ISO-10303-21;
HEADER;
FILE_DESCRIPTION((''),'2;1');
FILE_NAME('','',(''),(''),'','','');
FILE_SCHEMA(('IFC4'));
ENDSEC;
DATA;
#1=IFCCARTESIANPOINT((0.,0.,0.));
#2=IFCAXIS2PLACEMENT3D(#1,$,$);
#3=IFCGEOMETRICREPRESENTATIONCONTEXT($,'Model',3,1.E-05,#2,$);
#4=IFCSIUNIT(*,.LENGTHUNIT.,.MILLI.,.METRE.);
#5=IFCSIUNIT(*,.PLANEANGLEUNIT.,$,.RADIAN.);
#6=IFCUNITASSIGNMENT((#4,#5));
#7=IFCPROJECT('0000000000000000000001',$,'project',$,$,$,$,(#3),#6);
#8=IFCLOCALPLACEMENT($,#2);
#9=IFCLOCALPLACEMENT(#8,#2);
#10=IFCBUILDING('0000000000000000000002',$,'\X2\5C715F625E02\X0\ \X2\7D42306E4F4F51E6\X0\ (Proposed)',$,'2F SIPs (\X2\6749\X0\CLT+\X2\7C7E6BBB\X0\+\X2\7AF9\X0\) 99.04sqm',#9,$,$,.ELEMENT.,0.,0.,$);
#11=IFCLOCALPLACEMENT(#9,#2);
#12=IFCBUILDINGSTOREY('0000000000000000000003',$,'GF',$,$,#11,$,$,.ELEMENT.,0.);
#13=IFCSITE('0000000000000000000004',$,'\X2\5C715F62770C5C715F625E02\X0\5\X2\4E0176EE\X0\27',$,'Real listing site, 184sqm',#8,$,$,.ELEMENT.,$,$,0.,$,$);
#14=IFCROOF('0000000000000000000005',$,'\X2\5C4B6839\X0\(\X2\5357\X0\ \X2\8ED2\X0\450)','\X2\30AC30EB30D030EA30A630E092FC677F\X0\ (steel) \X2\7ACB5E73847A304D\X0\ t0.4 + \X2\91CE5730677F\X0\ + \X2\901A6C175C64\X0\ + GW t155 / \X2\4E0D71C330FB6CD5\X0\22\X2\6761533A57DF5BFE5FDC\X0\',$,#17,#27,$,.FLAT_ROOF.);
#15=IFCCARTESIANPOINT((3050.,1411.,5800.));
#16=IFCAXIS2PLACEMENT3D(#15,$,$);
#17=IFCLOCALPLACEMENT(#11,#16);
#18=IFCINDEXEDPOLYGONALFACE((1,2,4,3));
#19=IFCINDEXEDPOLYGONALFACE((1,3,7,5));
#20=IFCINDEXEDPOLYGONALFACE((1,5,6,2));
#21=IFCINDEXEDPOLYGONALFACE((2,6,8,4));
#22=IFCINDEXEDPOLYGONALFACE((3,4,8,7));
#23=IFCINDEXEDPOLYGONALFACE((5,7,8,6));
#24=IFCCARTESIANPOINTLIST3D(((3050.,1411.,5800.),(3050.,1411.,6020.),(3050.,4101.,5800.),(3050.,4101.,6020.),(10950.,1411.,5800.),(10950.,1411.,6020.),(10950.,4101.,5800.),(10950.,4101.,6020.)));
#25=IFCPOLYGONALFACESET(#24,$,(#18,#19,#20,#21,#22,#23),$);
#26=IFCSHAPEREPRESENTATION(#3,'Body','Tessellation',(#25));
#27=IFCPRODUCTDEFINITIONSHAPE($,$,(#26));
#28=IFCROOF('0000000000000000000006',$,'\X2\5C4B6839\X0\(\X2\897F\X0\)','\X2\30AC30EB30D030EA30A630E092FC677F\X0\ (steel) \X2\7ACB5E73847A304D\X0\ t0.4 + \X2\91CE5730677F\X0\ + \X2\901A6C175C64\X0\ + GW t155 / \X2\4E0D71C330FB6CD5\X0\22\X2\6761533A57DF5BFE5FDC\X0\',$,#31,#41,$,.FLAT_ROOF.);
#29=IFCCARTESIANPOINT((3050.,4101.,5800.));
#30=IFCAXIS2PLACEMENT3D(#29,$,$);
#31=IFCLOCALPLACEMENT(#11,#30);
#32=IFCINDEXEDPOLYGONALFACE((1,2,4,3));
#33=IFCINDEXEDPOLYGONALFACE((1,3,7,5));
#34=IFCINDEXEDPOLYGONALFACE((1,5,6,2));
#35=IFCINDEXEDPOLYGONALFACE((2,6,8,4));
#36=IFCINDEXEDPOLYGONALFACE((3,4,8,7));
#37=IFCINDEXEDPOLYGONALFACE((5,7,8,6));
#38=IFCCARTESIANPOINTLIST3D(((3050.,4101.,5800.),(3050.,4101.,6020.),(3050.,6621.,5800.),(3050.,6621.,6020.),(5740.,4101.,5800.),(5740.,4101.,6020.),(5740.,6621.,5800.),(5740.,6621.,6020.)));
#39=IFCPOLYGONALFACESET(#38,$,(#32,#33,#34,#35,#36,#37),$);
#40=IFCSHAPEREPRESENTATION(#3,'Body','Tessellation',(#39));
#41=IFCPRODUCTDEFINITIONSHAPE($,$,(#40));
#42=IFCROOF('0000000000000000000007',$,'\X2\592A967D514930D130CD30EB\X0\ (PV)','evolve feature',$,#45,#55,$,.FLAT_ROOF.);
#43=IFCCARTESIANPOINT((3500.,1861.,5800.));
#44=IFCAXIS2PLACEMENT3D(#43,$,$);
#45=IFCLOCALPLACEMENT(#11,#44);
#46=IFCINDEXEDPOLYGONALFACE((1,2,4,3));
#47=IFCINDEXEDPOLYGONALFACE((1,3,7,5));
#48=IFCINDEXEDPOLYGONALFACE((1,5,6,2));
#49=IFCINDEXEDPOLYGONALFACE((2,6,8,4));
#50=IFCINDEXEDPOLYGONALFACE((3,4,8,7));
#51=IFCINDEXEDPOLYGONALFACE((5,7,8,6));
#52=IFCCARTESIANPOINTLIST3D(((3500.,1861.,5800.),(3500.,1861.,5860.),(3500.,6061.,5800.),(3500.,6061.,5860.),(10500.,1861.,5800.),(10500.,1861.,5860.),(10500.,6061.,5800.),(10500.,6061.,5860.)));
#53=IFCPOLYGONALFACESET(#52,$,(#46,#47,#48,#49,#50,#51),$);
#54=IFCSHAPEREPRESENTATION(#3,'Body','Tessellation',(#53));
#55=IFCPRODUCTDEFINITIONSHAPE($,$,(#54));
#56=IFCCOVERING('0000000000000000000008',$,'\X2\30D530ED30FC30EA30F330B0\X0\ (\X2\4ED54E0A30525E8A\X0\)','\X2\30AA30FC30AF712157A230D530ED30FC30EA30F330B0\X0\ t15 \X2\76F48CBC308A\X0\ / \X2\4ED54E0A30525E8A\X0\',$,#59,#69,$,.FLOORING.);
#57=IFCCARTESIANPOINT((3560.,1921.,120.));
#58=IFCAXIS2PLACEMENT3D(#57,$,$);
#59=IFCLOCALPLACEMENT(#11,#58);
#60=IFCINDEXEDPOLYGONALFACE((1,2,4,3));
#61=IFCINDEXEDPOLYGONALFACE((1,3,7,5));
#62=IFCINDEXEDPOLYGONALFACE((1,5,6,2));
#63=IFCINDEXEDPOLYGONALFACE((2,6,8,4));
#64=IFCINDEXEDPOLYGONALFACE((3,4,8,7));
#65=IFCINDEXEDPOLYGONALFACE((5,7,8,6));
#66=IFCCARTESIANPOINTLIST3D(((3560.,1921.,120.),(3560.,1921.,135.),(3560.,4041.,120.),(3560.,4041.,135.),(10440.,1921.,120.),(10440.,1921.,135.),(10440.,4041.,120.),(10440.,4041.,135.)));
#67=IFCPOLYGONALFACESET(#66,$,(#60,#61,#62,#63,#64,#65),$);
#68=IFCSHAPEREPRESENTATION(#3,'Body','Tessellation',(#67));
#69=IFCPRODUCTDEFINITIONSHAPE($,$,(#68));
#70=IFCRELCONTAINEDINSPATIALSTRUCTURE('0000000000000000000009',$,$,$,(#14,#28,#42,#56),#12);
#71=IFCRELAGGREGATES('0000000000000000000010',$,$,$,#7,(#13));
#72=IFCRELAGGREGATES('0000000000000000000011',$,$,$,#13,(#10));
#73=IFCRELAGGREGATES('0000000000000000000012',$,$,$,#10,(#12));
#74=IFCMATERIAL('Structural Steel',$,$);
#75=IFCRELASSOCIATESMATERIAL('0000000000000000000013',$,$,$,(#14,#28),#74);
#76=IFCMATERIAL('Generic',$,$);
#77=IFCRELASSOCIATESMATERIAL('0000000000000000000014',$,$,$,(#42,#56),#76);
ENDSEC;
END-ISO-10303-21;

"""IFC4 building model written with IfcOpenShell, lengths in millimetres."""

from ifc_helpers import new_model, si_unit, frame, frame_2d, origin, place, context, project, spatial, rectangle, extrude, material, element, save


model = new_model("IFC4")

# Units and contexts
model_context = context("Model", 3, precision=1e-05, world=origin())
ifc_project = project(units=[si_unit("LENGTHUNIT", "METRE", prefix="MILLI"), si_unit("PLANEANGLEUNIT", "RADIAN")], contexts=[model_context])

# Site, building, storey
site_placement = place(None, origin())
site = spatial("IfcSite", under=ifc_project, at=site_placement, Name="山形県山形市5丁目27", ObjectType="Real listing site, 184sqm", CompositionType="ELEMENT", RefElevation=0.0)
building_placement = place(site_placement, origin())
building = spatial("IfcBuilding", under=site, at=building_placement, Name="山形市 終の住処 (Proposed)", ObjectType="2F SIPs (杉CLT+籾殻+竹) 99.04sqm", CompositionType="ELEMENT", ElevationOfRefHeight=0.0, ElevationOfTerrain=0.0)
storey_placement = place(building_placement, origin())
storey = spatial("IfcBuildingStorey", under=building, at=storey_placement, Name="GF", CompositionType="ELEMENT", Elevation=0.0)

# Shared definitions
ifc_material_1 = material(Name="Generic")

# Roofs
ifc_material_2 = material(Name="Structural Steel")
roof_1_placement = place(storey_placement, frame((3050.0, 1411.0, 5800.0)))
element("IfcRoof", 1, at=roof_1_placement, inside=storey, material=ifc_material_2, Name="屋根(南 軒450)", Description="ガルバリウム鋼板 (steel) 立平葺き t0.4 + 野地板 + 通気層 + GW t155 / 不燃・法22条区域対応", PredefinedType="FLAT_ROOF", context=model_context, shape_type="SweptSolid", body=[
    extrude(rectangle(XDim=7900.0, YDim=2690.0, at=frame_2d((3950.0, 1345.0))), frame((3050.0, 1411.0, 5800.0)), (0.0, 0.0, 1.0), 220.0),
])
roof_2_placement = place(storey_placement, frame((3050.0, 4101.0, 5800.0)))
element("IfcRoof", 2, at=roof_2_placement, inside=storey, material=ifc_material_2, Name="屋根(西)", Description="ガルバリウム鋼板 (steel) 立平葺き t0.4 + 野地板 + 通気層 + GW t155 / 不燃・法22条区域対応", PredefinedType="FLAT_ROOF", context=model_context, shape_type="SweptSolid", body=[
    extrude(rectangle(XDim=2690.0, YDim=2520.0, at=frame_2d((1345.0, 1260.0))), frame((3050.0, 4101.0, 5800.0)), (0.0, 0.0, 1.0), 220.0),
])
roof_3_placement = place(storey_placement, frame((3500.0, 1861.0, 5800.0)))
element("IfcRoof", 3, at=roof_3_placement, inside=storey, material=ifc_material_1, Name="太陽光パネル (PV)", Description="evolve feature", PredefinedType="FLAT_ROOF", context=model_context, shape_type="SweptSolid", body=[
    extrude(rectangle(XDim=7000.0, YDim=4200.0, at=frame_2d((3500.0, 2100.0))), frame((3500.0, 1861.0, 5800.0)), (0.0, 0.0, 1.0), 60.0),
])

# Covering
covering_placement = place(storey_placement, frame((3560.0, 1921.0, 120.0)))
element("IfcCovering", 4, at=covering_placement, inside=storey, material=ifc_material_1, Name="フローリング (仕上げ床)", Description="オーク無垢フローリング t15 直貼り / 仕上げ床", PredefinedType="FLOORING", context=model_context, shape_type="SweptSolid", body=[
    extrude(rectangle(XDim=6880.0, YDim=2120.0, at=frame_2d((3440.0, 1060.0))), frame((3560.0, 1921.0, 120.0)), (0.0, 0.0, 1.0), 15.0),
])

save(model, "model.ifc")
